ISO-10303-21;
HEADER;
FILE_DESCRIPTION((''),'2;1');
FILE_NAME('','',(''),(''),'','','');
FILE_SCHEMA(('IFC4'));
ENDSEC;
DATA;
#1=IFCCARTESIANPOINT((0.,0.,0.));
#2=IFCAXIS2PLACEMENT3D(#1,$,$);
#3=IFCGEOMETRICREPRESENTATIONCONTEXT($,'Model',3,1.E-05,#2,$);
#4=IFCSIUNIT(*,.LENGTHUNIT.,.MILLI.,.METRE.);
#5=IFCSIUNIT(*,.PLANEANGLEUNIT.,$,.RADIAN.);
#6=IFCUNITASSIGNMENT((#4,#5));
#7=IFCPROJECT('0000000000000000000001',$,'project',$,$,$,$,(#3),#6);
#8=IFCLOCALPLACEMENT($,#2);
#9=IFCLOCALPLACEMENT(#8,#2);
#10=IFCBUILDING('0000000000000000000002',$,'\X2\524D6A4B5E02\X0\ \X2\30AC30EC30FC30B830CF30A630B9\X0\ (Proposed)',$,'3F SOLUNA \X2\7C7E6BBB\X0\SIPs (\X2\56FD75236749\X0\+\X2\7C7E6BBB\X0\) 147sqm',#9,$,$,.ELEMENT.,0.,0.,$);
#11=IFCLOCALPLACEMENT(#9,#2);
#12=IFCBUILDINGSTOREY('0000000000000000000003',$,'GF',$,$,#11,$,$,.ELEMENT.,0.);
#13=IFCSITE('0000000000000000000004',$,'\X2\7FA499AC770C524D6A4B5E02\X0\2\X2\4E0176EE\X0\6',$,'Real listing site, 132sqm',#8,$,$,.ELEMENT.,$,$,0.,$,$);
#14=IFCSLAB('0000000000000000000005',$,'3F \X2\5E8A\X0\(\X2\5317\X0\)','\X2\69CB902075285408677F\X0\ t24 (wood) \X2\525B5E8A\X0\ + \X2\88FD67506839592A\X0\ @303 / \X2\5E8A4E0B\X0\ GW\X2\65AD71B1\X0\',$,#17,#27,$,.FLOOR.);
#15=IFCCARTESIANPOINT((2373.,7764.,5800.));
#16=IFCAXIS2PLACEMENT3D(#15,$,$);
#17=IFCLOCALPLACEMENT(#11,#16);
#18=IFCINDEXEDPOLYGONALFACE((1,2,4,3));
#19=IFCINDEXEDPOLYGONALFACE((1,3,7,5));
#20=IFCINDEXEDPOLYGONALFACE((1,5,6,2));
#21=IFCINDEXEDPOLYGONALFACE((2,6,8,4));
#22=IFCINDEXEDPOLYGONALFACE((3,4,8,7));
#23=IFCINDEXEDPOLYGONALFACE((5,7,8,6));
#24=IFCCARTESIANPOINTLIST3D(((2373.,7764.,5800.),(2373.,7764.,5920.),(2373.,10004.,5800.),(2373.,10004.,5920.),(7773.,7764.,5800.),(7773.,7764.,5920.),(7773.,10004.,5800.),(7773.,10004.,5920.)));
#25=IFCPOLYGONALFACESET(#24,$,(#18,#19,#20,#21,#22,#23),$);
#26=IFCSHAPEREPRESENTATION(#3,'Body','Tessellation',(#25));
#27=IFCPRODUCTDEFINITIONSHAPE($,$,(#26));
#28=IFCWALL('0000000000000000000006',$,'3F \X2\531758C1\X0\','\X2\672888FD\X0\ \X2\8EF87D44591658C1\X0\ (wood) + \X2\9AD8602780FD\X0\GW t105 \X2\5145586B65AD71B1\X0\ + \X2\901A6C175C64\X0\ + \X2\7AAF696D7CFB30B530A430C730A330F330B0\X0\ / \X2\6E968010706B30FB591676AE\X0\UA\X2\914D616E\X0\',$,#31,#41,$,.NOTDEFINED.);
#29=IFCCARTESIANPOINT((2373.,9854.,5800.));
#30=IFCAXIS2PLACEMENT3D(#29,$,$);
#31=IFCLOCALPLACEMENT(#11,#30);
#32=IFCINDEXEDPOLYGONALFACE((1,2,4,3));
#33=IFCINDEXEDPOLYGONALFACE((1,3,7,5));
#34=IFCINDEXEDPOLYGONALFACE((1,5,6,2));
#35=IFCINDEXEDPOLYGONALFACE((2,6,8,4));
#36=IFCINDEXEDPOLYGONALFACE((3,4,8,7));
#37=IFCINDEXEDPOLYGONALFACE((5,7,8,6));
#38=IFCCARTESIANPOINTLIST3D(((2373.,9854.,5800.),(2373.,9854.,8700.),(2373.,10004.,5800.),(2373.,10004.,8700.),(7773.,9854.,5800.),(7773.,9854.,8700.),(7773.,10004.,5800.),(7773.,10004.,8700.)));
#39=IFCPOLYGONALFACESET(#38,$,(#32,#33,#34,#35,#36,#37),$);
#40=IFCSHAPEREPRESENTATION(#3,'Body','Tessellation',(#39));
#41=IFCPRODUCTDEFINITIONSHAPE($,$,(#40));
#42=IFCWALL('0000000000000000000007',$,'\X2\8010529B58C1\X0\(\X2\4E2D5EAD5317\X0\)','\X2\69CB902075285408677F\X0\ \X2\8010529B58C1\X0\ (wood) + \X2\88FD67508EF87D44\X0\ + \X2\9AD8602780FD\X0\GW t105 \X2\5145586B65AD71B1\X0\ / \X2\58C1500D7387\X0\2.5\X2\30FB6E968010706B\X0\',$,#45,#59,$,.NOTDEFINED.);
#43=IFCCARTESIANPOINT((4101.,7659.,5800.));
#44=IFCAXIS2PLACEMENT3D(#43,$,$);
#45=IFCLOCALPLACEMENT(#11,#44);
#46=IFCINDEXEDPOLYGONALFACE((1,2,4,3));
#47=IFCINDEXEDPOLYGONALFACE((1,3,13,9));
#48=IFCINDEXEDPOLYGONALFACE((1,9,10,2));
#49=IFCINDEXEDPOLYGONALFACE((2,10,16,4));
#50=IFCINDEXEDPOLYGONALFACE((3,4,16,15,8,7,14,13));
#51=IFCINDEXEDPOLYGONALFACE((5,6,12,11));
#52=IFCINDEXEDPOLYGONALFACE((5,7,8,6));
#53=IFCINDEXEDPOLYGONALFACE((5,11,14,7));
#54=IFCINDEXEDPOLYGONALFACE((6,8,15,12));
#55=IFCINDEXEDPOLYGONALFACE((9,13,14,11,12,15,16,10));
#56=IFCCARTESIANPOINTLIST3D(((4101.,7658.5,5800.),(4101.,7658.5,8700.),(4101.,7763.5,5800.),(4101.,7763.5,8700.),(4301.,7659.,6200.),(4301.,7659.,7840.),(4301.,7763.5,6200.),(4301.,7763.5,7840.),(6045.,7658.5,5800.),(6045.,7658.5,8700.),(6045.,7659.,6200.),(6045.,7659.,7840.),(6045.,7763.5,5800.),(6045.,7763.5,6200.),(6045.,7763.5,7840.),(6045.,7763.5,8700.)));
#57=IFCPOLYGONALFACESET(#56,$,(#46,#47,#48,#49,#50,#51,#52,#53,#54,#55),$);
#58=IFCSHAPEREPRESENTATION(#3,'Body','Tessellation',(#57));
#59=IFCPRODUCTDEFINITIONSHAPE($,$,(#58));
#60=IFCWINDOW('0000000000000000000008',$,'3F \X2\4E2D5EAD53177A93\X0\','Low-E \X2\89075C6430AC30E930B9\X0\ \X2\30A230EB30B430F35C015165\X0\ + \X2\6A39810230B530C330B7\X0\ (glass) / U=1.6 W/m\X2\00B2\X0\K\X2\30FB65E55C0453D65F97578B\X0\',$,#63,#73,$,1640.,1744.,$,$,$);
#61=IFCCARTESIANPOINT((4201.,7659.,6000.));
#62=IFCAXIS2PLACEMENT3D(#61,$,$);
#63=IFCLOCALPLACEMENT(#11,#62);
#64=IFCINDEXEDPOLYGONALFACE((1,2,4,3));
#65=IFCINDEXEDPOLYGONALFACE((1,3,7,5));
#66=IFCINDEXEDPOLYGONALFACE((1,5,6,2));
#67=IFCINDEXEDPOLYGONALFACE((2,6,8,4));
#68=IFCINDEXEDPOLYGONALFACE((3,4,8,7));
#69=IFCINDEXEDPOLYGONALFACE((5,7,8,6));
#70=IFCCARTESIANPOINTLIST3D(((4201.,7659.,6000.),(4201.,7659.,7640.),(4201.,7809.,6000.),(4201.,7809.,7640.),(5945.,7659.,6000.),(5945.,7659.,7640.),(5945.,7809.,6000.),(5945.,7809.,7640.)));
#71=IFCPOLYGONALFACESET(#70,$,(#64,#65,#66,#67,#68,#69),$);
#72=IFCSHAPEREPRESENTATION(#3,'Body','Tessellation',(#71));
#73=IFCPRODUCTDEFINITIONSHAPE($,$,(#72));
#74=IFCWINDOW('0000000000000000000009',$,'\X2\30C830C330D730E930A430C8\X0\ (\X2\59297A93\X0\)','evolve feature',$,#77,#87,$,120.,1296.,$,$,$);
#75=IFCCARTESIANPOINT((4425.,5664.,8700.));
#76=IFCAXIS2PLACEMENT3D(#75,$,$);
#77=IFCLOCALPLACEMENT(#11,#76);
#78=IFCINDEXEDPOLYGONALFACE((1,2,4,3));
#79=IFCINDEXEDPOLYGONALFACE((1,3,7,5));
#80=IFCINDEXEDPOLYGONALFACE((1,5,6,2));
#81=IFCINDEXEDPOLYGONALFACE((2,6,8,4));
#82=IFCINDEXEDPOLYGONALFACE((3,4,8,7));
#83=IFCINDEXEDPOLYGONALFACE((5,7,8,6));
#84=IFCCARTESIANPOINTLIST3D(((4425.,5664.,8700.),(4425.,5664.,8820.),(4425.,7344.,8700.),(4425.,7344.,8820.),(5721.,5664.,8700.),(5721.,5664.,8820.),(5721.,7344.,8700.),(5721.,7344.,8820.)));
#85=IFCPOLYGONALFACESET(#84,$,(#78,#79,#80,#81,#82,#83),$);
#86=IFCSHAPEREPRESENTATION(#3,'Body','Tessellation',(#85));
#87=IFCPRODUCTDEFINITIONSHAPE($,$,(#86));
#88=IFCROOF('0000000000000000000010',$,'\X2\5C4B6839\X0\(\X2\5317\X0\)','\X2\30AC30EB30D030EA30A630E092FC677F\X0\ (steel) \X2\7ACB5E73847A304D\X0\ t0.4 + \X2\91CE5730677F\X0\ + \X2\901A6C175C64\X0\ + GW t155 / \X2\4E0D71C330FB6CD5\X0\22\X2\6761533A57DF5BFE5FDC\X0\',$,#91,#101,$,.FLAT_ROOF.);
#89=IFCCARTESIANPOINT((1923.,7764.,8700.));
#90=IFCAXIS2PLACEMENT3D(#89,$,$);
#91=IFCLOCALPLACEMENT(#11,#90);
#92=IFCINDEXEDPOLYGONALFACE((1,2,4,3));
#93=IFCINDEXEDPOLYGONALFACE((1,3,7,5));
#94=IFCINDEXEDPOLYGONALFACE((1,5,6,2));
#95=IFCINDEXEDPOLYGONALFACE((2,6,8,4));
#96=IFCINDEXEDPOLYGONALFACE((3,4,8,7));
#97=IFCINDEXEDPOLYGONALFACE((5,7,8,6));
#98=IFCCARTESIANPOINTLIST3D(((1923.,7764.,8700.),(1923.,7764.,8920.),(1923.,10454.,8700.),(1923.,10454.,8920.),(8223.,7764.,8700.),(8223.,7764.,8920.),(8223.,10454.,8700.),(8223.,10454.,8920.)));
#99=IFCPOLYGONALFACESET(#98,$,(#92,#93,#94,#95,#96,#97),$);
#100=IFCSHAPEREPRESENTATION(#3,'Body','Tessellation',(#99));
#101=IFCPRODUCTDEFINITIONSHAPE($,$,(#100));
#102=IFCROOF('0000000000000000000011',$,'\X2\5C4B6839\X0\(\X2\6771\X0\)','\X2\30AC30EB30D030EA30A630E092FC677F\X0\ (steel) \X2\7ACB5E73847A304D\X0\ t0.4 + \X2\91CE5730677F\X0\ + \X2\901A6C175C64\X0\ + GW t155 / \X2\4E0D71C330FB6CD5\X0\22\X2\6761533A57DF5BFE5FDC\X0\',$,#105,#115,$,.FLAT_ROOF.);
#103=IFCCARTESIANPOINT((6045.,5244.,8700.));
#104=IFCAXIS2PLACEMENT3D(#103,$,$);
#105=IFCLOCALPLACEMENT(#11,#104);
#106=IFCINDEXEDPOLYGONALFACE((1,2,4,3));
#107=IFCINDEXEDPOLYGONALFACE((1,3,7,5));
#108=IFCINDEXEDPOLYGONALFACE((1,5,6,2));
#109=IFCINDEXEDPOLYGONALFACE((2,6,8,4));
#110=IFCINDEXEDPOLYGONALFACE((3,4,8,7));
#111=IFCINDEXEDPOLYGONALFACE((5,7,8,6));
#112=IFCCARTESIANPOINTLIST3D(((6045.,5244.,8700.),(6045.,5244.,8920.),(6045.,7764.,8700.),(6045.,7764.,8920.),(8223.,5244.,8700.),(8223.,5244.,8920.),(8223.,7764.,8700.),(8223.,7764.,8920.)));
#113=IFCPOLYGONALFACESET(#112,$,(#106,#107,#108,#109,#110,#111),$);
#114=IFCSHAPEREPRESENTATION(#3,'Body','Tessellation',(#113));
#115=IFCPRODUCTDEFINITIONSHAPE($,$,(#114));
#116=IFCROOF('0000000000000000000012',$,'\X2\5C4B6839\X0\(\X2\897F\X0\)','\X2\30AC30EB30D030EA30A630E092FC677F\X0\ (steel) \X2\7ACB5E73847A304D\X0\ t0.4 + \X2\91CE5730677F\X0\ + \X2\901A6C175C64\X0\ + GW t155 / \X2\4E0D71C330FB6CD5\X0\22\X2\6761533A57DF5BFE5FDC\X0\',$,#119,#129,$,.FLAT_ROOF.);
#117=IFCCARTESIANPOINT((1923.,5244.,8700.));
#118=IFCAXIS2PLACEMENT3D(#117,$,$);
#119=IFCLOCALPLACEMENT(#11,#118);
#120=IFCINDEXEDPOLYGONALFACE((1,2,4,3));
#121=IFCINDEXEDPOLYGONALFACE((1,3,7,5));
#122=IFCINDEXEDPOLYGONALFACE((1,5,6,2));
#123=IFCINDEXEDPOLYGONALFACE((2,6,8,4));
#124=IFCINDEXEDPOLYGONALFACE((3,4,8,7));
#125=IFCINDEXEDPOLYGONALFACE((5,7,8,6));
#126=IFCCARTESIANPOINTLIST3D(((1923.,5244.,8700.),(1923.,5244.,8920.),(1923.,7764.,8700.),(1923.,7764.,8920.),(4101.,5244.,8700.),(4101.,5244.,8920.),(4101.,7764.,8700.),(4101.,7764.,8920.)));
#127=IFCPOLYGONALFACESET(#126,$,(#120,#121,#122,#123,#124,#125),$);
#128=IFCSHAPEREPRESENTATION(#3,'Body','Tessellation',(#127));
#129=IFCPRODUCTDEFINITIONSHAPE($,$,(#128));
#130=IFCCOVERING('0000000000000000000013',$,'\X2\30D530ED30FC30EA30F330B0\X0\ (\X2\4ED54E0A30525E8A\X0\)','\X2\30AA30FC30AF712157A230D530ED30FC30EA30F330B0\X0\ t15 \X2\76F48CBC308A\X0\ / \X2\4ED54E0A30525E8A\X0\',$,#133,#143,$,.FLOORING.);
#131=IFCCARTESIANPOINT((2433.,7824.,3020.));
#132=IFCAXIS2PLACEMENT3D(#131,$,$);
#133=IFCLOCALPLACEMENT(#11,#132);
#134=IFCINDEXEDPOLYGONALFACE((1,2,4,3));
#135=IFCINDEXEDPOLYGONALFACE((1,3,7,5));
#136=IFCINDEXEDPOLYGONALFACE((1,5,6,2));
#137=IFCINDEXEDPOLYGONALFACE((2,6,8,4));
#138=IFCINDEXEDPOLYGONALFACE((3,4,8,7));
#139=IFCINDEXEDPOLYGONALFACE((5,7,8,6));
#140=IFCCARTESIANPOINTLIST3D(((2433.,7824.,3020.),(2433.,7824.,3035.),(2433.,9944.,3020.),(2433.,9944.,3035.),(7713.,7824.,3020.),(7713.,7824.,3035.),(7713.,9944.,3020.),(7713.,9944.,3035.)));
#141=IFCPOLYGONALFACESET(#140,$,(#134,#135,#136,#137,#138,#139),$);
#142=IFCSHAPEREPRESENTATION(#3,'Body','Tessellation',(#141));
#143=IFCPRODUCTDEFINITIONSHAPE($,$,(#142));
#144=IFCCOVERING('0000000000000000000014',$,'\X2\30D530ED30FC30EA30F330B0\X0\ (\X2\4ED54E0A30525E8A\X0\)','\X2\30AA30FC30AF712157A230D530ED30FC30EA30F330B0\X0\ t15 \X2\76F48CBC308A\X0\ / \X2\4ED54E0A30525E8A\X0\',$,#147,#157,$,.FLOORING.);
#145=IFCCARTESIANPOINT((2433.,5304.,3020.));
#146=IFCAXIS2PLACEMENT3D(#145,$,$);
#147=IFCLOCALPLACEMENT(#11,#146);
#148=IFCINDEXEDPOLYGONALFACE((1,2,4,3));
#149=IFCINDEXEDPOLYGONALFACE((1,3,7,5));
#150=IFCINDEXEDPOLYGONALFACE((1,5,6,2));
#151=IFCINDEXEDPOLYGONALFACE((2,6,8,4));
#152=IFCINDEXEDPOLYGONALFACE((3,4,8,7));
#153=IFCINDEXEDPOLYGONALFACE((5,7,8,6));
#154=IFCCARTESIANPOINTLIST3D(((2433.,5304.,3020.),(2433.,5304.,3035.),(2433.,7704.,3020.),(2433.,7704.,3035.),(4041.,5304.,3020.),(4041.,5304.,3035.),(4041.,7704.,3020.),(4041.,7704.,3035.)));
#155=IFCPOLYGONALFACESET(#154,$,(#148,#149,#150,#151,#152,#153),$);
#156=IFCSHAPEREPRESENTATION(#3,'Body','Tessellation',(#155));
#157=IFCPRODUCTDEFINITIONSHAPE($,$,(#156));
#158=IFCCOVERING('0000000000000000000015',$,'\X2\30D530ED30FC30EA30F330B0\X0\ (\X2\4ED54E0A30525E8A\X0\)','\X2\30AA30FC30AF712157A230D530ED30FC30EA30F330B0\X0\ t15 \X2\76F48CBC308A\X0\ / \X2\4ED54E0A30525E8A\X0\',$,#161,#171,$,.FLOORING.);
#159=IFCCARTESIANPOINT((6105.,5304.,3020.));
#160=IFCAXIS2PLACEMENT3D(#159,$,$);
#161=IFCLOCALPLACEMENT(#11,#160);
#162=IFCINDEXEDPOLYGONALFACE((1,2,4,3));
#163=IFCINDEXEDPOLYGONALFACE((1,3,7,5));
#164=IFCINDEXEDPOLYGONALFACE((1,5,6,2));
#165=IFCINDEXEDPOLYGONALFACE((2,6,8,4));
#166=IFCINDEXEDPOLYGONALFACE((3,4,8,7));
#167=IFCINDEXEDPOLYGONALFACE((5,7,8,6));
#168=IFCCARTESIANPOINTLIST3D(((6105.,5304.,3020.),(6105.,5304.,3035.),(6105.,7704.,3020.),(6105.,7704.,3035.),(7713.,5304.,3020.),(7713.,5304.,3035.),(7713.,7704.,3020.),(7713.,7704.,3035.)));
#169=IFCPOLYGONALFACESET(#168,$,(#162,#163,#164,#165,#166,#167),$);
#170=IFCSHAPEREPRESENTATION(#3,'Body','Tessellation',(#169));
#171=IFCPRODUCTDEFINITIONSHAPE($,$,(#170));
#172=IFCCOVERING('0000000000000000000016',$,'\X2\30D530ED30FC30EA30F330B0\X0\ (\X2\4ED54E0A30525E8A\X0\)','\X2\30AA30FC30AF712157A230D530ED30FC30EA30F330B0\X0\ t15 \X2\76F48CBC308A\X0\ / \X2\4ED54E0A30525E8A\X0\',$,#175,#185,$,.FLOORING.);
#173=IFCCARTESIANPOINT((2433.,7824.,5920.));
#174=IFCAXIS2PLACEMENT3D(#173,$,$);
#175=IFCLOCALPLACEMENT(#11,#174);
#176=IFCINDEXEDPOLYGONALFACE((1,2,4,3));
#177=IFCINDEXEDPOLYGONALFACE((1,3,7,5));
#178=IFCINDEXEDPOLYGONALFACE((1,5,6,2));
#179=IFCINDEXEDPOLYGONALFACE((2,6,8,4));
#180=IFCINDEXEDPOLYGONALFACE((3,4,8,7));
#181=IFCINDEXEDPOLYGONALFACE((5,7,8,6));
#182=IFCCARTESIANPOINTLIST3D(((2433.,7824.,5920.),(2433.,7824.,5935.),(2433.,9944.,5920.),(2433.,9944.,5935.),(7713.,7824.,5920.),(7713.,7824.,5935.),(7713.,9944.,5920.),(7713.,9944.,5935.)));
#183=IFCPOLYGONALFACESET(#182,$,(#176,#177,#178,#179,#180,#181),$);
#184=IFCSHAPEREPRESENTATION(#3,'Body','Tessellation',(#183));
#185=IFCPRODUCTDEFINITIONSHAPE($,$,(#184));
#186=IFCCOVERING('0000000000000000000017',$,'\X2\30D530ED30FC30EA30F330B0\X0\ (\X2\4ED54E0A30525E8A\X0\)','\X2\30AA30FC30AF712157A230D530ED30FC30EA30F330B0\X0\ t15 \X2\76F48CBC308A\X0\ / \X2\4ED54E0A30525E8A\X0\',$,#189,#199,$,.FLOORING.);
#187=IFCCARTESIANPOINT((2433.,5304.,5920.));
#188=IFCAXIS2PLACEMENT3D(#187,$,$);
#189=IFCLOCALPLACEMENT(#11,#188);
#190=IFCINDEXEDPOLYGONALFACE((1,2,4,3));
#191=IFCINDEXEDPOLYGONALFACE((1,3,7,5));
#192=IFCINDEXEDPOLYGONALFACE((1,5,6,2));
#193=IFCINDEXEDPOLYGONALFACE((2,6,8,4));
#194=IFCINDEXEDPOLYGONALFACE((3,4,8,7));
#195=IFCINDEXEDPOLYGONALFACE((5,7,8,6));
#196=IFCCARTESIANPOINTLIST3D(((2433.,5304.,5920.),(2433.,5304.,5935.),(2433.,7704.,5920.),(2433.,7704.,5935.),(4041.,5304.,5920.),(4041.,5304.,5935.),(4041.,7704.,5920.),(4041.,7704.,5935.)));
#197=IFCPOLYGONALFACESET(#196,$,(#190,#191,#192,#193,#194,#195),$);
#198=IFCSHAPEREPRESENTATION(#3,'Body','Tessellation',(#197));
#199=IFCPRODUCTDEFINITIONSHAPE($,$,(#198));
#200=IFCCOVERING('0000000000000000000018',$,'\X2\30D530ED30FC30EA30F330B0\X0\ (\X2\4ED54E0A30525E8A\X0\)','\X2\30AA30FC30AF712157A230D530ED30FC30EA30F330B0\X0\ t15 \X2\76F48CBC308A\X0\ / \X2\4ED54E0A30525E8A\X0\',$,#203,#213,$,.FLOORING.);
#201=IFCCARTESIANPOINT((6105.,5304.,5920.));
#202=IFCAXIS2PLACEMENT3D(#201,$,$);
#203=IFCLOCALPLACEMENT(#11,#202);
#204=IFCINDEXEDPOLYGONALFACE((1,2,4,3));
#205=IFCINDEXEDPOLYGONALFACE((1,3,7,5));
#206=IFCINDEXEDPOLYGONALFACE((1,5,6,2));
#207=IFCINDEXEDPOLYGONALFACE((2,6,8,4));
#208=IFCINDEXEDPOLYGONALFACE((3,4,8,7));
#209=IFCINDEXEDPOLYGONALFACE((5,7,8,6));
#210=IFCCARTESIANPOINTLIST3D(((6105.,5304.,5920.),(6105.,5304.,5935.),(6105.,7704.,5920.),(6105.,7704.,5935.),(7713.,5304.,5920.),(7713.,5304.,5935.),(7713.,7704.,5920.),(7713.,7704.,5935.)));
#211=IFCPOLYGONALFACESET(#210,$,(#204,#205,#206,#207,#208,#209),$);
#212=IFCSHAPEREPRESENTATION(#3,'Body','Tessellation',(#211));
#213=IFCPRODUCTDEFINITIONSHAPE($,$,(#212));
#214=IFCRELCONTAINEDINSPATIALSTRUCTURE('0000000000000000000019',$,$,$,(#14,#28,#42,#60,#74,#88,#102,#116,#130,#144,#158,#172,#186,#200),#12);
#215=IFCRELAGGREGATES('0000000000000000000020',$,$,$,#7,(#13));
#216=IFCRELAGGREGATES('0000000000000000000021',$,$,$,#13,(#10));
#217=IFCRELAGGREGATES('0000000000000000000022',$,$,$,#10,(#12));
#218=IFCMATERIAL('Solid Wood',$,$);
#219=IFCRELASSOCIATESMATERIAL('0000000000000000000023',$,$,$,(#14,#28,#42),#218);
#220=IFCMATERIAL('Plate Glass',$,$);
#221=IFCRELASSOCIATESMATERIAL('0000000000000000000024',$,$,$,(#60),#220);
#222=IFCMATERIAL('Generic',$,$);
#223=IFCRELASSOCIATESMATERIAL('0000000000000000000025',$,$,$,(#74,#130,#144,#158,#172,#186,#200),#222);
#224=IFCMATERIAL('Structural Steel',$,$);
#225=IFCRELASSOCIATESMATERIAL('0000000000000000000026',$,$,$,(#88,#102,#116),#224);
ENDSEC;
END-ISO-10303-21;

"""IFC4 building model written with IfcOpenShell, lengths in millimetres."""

from ifc_helpers import new_model, si_unit, frame, frame_2d, origin, place, context, project, spatial, rectangle, extrude, material, element, fill, save


model = new_model("IFC4")

# Units and contexts
model_context = context("Model", 3, precision=1e-05, world=origin())
ifc_project = project(units=[si_unit("LENGTHUNIT", "METRE", prefix="MILLI"), si_unit("PLANEANGLEUNIT", "RADIAN")], contexts=[model_context])

# Site, building, storey
site_placement = place(None, origin())
site = spatial("IfcSite", under=ifc_project, at=site_placement, Name="群馬県前橋市2丁目6", ObjectType="Real listing site, 132sqm", CompositionType="ELEMENT", RefElevation=0.0)
building_placement = place(site_placement, origin())
building = spatial("IfcBuilding", under=site, at=building_placement, Name="前橋市 ガレージハウス (Proposed)", ObjectType="3F SOLUNA 籾殻SIPs (国産杉+籾殻) 147sqm", CompositionType="ELEMENT", ElevationOfRefHeight=0.0, ElevationOfTerrain=0.0)
storey_placement = place(building_placement, origin())
storey = spatial("IfcBuildingStorey", under=building, at=storey_placement, Name="GF", CompositionType="ELEMENT", Elevation=0.0)

# Slab
ifc_material_1 = material(Name="Solid Wood")
slab_placement = place(storey_placement, frame((2373.0, 7764.0, 5800.0)))
element("IfcSlab", 1, at=slab_placement, inside=storey, material=ifc_material_1, Name="3F 床(北)", Description="構造用合板 t24 (wood) 剛床 + 製材根太 @303 / 床下 GW断熱", PredefinedType="FLOOR", context=model_context, shape_type="SweptSolid", body=[
    extrude(rectangle(XDim=5400.0, YDim=2240.0, at=frame_2d((2700.0, 1120.0))), frame((2373.0, 7764.0, 5800.0)), (0.0, 0.0, 1.0), 120.0),
])

# Wall
wall_1_placement = place(storey_placement, frame((2373.0, 9854.0, 5800.0)))
element("IfcWall", 2, at=wall_1_placement, inside=storey, material=ifc_material_1, Name="3F 北壁", Description="木製 軸組外壁 (wood) + 高性能GW t105 充填断熱 + 通気層 + 窯業系サイディング / 準耐火・外皮UA配慮", PredefinedType="NOTDEFINED", context=model_context, shape_type="SweptSolid", body=[
    extrude(rectangle(XDim=5400.0, YDim=150.0, at=frame_2d((2700.0, 75.0))), frame((2373.0, 9854.0, 5800.0)), (0.0, 0.0, 1.0), 2900.0),
])

# Wall, opening, window
wall_2_placement = place(storey_placement, frame((4101.0, 7659.0, 5800.0)))
wall_2 = element("IfcWall", 3, at=wall_2_placement, inside=storey, material=ifc_material_1, Name="耐力壁(中庭北)", Description="構造用合板 耐力壁 (wood) + 製材軸組 + 高性能GW t105 充填断熱 / 壁倍率2.5・準耐火", PredefinedType="NOTDEFINED", context=model_context, shape_type="SweptSolid", body=[
    extrude(rectangle(XDim=1944.0, YDim=105.0, at=frame_2d((972.0, 52.0))), frame((4101.0, 7659.0, 5800.0)), (0.0, 0.0, 1.0), 2900.0),
])
opening_placement = place(storey_placement, frame((4201.0, 7659.0, 6000.0)))
opening = element("IfcOpeningElement", 4, at=opening_placement, cuts=wall_2, PredefinedType="NOTDEFINED", context=model_context, shape_type="SweptSolid", body=[
    extrude(rectangle(XDim=1744.0, YDim=150.0, at=frame_2d((872.0, 75.0))), frame((4201.0, 7659.0, 6000.0)), (0.0, 0.0, 1.0), 1640.0),
])
ifc_material_2 = material(Name="Plate Glass")
window_1_placement = place(storey_placement, frame((4201.0, 7659.0, 6000.0)))
window_1 = element("IfcWindow", 5, at=window_1_placement, inside=storey, material=ifc_material_2, Name="3F 中庭北窓", Description="Low-E 複層ガラス アルゴン封入 + 樹脂サッシ (glass) / U=1.6 W/m²K・日射取得型", OverallHeight=1640.0, OverallWidth=1744.0, context=model_context, shape_type="SweptSolid", body=[
    extrude(rectangle(XDim=1744.0, YDim=150.0, at=frame_2d((872.0, 75.0))), frame((4201.0, 7659.0, 6000.0)), (0.0, 0.0, 1.0), 1640.0),
])
fill(opening, window_1)

# Window
ifc_material_3 = material(Name="Generic")
window_2_placement = place(storey_placement, frame((4425.0, 5664.0, 8700.0)))
element("IfcWindow", 6, at=window_2_placement, inside=storey, material=ifc_material_3, Name="トップライト (天窓)", Description="evolve feature", OverallHeight=120.0, OverallWidth=1296.0, context=model_context, shape_type="SweptSolid", body=[
    extrude(rectangle(XDim=1296.0, YDim=1680.0, at=frame_2d((648.0, 840.0))), frame((4425.0, 5664.0, 8700.0)), (0.0, 0.0, 1.0), 120.0),
])

# Roofs
ifc_material_4 = material(Name="Structural Steel")
roof_1_placement = place(storey_placement, frame((1923.0, 7764.0, 8700.0)))
element("IfcRoof", 7, at=roof_1_placement, inside=storey, material=ifc_material_4, Name="屋根(北)", Description="ガルバリウム鋼板 (steel) 立平葺き t0.4 + 野地板 + 通気層 + GW t155 / 不燃・法22条区域対応", PredefinedType="FLAT_ROOF", context=model_context, shape_type="SweptSolid", body=[
    extrude(rectangle(XDim=6300.0, YDim=2690.0, at=frame_2d((3150.0, 1345.0))), frame((1923.0, 7764.0, 8700.0)), (0.0, 0.0, 1.0), 220.0),
])
roof_2_placement = place(storey_placement, frame((6045.0, 5244.0, 8700.0)))
element("IfcRoof", 8, at=roof_2_placement, inside=storey, material=ifc_material_4, Name="屋根(東)", Description="ガルバリウム鋼板 (steel) 立平葺き t0.4 + 野地板 + 通気層 + GW t155 / 不燃・法22条区域対応", PredefinedType="FLAT_ROOF", context=model_context, shape_type="SweptSolid", body=[
    extrude(rectangle(XDim=2178.0, YDim=2520.0, at=frame_2d((1089.0, 1260.0))), frame((6045.0, 5244.0, 8700.0)), (0.0, 0.0, 1.0), 220.0),
])
roof_3_placement = place(storey_placement, frame((1923.0, 5244.0, 8700.0)))
element("IfcRoof", 9, at=roof_3_placement, inside=storey, material=ifc_material_4, Name="屋根(西)", Description="ガルバリウム鋼板 (steel) 立平葺き t0.4 + 野地板 + 通気層 + GW t155 / 不燃・法22条区域対応", PredefinedType="FLAT_ROOF", context=model_context, shape_type="SweptSolid", body=[
    extrude(rectangle(XDim=2178.0, YDim=2520.0, at=frame_2d((1089.0, 1260.0))), frame((1923.0, 5244.0, 8700.0)), (0.0, 0.0, 1.0), 220.0),
])

# Coverings
covering_1_placement = place(storey_placement, frame((2433.0, 7824.0, 3020.0)))
element("IfcCovering", 10, at=covering_1_placement, inside=storey, material=ifc_material_3, Name="フローリング (仕上げ床)", Description="オーク無垢フローリング t15 直貼り / 仕上げ床", PredefinedType="FLOORING", context=model_context, shape_type="SweptSolid", body=[
    extrude(rectangle(XDim=5280.0, YDim=2120.0, at=frame_2d((2640.0, 1060.0))), frame((2433.0, 7824.0, 3020.0)), (0.0, 0.0, 1.0), 15.0),
])
covering_2_placement = place(storey_placement, frame((2433.0, 5304.0, 3020.0)))
element("IfcCovering", 11, at=covering_2_placement, inside=storey, material=ifc_material_3, Name="フローリング (仕上げ床)", Description="オーク無垢フローリング t15 直貼り / 仕上げ床", PredefinedType="FLOORING", context=model_context, shape_type="SweptSolid", body=[
    extrude(rectangle(XDim=1608.0, YDim=2400.0, at=frame_2d((804.0, 1200.0))), frame((2433.0, 5304.0, 3020.0)), (0.0, 0.0, 1.0), 15.0),
])
covering_3_placement = place(storey_placement, frame((6105.0, 5304.0, 3020.0)))
element("IfcCovering", 12, at=covering_3_placement, inside=storey, material=ifc_material_3, Name="フローリング (仕上げ床)", Description="オーク無垢フローリング t15 直貼り / 仕上げ床", PredefinedType="FLOORING", context=model_context, shape_type="SweptSolid", body=[
    extrude(rectangle(XDim=1608.0, YDim=2400.0, at=frame_2d((804.0, 1200.0))), frame((6105.0, 5304.0, 3020.0)), (0.0, 0.0, 1.0), 15.0),
])
covering_4_placement = place(storey_placement, frame((2433.0, 7824.0, 5920.0)))
element("IfcCovering", 13, at=covering_4_placement, inside=storey, material=ifc_material_3, Name="フローリング (仕上げ床)", Description="オーク無垢フローリング t15 直貼り / 仕上げ床", PredefinedType="FLOORING", context=model_context, shape_type="SweptSolid", body=[
    extrude(rectangle(XDim=5280.0, YDim=2120.0, at=frame_2d((2640.0, 1060.0))), frame((2433.0, 7824.0, 5920.0)), (0.0, 0.0, 1.0), 15.0),
])
covering_5_placement = place(storey_placement, frame((2433.0, 5304.0, 5920.0)))
element("IfcCovering", 14, at=covering_5_placement, inside=storey, material=ifc_material_3, Name="フローリング (仕上げ床)", Description="オーク無垢フローリング t15 直貼り / 仕上げ床", PredefinedType="FLOORING", context=model_context, shape_type="SweptSolid", body=[
    extrude(rectangle(XDim=1608.0, YDim=2400.0, at=frame_2d((804.0, 1200.0))), frame((2433.0, 5304.0, 5920.0)), (0.0, 0.0, 1.0), 15.0),
])
covering_6_placement = place(storey_placement, frame((6105.0, 5304.0, 5920.0)))
element("IfcCovering", 15, at=covering_6_placement, inside=storey, material=ifc_material_3, Name="フローリング (仕上げ床)", Description="オーク無垢フローリング t15 直貼り / 仕上げ床", PredefinedType="FLOORING", context=model_context, shape_type="SweptSolid", body=[
    extrude(rectangle(XDim=1608.0, YDim=2400.0, at=frame_2d((804.0, 1200.0))), frame((6105.0, 5304.0, 5920.0)), (0.0, 0.0, 1.0), 15.0),
])

save(model, "model.ifc")
